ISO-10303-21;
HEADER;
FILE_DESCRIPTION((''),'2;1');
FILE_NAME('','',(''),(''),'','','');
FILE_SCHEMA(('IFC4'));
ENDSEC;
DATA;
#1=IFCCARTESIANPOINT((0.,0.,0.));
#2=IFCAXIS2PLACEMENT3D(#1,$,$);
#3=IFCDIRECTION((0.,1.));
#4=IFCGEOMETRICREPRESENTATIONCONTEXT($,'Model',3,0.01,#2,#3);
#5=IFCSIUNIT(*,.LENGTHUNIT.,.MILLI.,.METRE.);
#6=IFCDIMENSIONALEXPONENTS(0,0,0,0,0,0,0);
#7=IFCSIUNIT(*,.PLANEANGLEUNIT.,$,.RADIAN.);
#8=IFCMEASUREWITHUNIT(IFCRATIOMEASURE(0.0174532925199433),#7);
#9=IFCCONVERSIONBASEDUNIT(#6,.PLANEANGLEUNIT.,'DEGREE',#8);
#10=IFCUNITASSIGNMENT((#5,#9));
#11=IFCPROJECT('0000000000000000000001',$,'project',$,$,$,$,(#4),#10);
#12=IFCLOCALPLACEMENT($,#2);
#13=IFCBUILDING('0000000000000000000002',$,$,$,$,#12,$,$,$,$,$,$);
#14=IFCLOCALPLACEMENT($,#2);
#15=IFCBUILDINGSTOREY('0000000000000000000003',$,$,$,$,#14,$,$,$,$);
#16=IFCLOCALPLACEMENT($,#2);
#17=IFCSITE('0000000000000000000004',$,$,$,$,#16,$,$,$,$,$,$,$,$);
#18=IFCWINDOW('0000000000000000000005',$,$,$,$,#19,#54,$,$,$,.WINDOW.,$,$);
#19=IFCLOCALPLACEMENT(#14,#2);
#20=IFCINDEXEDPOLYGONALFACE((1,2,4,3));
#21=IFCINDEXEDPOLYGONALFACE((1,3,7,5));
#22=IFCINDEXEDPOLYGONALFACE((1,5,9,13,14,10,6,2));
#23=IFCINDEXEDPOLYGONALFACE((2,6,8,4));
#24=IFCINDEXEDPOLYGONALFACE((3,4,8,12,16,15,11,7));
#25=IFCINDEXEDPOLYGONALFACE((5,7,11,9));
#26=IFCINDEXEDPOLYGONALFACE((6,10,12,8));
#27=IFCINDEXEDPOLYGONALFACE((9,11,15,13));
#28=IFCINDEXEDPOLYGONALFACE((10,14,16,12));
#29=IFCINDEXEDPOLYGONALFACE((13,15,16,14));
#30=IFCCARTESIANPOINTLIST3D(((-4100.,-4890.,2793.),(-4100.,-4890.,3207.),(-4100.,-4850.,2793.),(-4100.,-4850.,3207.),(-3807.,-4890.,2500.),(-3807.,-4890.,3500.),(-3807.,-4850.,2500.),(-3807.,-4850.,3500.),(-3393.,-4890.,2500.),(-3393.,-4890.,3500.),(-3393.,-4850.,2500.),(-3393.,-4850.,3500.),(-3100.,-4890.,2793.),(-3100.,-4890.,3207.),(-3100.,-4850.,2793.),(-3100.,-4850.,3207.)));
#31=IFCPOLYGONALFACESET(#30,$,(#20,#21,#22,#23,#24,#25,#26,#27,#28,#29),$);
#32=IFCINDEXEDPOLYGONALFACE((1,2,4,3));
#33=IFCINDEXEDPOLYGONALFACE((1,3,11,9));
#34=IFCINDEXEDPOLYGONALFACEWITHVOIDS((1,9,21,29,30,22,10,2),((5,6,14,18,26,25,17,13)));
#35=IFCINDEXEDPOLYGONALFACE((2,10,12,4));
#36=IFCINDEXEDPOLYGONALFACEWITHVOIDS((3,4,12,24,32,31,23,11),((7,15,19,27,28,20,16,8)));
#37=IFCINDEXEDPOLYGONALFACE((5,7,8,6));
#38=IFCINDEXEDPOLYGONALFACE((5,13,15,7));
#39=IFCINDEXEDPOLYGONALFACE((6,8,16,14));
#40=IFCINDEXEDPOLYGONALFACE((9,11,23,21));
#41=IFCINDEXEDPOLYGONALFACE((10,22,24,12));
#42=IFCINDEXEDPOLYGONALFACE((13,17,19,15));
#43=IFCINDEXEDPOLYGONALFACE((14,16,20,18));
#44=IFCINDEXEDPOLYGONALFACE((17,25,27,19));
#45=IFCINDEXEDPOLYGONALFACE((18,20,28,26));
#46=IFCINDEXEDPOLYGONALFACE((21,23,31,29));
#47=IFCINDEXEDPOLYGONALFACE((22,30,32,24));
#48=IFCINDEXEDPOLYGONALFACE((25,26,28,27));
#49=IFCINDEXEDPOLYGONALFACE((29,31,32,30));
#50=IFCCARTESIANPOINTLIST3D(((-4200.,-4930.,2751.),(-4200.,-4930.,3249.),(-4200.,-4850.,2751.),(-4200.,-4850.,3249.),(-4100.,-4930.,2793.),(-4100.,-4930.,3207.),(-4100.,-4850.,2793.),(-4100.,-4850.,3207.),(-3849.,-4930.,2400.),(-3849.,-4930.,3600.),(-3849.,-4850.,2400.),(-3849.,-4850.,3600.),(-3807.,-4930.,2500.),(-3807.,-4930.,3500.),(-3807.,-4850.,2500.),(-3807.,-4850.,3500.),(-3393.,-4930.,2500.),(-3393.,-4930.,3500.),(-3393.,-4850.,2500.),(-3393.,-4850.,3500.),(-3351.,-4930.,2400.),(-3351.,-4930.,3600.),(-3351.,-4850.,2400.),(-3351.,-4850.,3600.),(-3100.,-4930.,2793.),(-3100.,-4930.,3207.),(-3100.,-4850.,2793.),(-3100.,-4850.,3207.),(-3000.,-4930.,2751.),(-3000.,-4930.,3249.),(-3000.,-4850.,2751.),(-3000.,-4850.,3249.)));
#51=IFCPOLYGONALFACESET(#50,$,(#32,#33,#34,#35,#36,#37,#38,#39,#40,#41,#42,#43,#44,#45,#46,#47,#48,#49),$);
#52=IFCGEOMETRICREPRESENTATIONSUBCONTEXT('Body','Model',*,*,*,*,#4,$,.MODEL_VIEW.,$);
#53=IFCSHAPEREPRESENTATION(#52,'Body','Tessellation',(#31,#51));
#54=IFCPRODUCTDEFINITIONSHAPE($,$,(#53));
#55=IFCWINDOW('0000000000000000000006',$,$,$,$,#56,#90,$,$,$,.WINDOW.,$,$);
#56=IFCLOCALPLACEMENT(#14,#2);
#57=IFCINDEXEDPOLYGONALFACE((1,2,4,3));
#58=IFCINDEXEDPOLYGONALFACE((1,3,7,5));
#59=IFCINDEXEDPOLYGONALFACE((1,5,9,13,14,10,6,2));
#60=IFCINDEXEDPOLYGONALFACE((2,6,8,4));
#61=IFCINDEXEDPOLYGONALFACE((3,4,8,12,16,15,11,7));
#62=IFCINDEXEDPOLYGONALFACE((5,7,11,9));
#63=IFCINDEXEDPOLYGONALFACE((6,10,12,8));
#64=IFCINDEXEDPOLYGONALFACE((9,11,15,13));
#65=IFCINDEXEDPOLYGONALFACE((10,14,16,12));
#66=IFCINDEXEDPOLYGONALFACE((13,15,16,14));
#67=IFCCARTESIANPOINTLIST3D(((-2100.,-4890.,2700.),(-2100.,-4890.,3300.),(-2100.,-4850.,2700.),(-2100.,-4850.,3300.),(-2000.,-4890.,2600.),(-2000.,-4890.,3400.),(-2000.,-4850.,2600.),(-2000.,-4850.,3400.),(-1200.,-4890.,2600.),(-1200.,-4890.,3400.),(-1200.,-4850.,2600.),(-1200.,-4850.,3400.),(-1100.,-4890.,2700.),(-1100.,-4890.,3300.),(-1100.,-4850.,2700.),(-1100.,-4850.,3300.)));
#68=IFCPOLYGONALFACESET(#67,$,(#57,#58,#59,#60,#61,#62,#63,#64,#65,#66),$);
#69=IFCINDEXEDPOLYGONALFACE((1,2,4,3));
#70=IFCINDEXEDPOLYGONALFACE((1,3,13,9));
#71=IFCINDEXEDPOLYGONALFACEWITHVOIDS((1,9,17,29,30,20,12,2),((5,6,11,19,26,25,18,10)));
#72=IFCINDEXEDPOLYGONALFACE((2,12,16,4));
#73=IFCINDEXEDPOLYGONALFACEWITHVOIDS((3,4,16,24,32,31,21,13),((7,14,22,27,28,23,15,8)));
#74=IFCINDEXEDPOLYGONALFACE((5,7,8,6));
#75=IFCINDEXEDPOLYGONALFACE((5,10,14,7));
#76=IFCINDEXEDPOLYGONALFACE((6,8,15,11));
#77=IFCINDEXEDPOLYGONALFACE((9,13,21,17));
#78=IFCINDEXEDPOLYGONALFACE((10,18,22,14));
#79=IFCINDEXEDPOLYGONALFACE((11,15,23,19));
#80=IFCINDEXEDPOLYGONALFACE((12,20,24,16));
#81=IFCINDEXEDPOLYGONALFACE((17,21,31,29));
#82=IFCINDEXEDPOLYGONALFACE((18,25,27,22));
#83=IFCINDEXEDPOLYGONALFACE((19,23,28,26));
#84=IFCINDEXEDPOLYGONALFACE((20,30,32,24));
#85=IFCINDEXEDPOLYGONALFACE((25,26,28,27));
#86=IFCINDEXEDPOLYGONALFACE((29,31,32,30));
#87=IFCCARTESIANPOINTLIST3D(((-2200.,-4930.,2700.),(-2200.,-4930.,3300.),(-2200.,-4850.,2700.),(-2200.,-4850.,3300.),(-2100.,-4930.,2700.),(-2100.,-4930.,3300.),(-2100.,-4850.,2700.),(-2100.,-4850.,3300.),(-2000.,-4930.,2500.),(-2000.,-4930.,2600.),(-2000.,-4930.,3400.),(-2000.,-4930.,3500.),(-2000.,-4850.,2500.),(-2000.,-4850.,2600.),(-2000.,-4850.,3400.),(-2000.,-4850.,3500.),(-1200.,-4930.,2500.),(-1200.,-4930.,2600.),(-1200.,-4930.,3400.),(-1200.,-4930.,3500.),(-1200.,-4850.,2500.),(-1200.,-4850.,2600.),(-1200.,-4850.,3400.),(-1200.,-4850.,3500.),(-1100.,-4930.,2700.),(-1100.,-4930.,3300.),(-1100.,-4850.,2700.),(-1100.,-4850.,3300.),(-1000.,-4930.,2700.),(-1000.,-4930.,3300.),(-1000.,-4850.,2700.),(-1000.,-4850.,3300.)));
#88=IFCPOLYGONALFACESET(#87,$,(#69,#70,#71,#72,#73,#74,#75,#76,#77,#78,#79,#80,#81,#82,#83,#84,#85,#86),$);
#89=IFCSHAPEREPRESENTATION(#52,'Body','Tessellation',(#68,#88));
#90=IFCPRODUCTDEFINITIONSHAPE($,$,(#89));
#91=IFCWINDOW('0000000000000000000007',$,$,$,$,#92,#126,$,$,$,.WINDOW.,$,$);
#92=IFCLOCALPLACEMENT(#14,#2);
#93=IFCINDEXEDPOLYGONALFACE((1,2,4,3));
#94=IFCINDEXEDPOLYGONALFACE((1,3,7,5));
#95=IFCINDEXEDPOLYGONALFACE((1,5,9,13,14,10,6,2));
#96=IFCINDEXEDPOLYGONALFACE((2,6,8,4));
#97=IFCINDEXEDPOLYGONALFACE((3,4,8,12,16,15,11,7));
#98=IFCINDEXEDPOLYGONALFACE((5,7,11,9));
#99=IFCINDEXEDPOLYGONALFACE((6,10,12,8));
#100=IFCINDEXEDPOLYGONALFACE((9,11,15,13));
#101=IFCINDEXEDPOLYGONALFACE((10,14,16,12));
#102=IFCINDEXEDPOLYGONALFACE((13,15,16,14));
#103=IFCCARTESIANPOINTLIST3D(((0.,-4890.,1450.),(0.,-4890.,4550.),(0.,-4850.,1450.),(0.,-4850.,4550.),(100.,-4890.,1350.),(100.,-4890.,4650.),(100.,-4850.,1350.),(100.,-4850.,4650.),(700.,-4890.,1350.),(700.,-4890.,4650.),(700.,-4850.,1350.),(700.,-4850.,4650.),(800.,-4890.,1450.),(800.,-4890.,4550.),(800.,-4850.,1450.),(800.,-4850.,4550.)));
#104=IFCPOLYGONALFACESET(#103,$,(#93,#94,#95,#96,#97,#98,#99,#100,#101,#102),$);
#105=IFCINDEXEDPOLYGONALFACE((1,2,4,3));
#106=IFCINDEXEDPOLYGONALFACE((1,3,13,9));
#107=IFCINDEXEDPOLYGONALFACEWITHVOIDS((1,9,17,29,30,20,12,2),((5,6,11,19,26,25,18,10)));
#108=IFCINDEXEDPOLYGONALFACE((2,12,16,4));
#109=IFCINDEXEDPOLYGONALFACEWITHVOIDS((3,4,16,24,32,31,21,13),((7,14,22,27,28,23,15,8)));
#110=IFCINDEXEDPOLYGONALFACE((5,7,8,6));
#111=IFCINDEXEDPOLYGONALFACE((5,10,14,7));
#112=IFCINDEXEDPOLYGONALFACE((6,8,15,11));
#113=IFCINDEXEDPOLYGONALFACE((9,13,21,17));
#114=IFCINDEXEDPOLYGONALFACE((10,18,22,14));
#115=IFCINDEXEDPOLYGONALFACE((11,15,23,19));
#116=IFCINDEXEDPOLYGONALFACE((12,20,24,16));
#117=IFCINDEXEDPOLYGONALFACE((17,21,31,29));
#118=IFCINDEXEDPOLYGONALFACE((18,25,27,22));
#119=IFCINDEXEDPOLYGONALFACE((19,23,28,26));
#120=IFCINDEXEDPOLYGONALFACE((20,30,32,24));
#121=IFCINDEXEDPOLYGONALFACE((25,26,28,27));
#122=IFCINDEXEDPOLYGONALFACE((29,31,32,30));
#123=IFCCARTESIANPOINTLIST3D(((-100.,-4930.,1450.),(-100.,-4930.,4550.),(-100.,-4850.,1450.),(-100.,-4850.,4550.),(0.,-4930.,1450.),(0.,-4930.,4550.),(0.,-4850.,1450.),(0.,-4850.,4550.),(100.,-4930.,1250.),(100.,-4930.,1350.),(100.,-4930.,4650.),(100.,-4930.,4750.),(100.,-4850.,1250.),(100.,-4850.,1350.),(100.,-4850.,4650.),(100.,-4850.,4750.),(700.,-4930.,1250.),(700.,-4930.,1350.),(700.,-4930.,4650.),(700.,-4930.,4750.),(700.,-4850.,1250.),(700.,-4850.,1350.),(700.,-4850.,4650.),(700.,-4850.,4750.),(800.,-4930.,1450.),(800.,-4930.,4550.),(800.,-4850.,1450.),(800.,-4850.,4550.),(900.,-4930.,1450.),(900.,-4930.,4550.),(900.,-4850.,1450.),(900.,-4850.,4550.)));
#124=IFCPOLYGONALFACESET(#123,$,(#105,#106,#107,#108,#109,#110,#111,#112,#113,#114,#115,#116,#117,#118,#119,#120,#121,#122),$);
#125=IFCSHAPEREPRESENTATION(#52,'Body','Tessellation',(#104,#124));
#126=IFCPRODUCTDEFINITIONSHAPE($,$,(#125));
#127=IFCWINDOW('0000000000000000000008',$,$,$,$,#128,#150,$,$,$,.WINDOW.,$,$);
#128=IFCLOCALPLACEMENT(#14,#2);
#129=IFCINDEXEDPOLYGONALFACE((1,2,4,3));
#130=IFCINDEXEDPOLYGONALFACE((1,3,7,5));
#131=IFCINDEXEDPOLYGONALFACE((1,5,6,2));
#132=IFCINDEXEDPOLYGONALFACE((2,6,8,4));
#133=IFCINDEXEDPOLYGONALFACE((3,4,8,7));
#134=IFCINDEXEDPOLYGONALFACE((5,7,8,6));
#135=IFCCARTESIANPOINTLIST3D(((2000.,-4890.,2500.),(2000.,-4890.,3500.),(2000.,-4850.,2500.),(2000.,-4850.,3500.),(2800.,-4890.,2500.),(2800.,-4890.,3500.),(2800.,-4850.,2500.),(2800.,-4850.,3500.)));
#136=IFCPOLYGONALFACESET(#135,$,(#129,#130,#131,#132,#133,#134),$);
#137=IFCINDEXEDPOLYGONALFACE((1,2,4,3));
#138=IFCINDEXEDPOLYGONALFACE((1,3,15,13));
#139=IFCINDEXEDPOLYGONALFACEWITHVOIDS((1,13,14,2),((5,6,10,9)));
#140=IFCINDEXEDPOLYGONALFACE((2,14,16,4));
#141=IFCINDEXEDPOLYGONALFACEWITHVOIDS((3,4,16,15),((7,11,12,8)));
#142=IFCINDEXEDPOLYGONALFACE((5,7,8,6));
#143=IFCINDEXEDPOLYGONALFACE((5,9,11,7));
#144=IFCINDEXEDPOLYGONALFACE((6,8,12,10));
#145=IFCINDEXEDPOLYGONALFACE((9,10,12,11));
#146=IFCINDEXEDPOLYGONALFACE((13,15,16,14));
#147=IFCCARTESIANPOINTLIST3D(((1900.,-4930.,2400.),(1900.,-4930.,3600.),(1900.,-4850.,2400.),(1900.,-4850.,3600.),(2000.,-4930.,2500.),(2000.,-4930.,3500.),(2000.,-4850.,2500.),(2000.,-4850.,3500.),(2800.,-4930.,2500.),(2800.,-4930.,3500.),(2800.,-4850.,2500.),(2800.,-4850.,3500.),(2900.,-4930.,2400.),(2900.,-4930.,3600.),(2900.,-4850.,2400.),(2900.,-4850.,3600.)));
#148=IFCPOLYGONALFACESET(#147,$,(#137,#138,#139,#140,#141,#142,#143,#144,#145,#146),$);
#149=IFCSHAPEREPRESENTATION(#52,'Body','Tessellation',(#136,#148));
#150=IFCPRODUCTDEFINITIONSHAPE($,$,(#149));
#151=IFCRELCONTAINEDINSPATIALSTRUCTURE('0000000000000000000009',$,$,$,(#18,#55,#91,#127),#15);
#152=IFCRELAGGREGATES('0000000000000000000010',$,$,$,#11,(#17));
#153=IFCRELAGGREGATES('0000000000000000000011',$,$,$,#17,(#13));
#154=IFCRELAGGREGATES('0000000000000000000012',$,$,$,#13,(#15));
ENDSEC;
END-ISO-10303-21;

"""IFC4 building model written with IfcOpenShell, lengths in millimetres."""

from ifc_helpers import new_model, entity, si_unit, converted_unit, direction, frame, origin, place, context, subcontext, project, spatial, element, save


model = new_model("IFC4")

# Units and contexts
model_context = context("Model", 3, precision=0.01, world=origin(), true_north=direction((0.0, 1.0)))
body_context = subcontext(model_context, "Body", "Model", "MODEL_VIEW")
ifc_project = project(units=[si_unit("LENGTHUNIT", "METRE", prefix="MILLI"), converted_unit("PLANEANGLEUNIT", "DEGREE", entity("IfcRatioMeasure", 0.0174532925199433), si_unit("PLANEANGLEUNIT", "RADIAN"), dimensions=[0, 0, 0, 0, 0, 0, 0])], contexts=[model_context])

# Site, building, storey
site_placement = place(None, origin())
site = spatial("IfcSite", under=ifc_project, at=site_placement)
building_placement = place(None, origin())
building = spatial("IfcBuilding", under=site, at=building_placement)
storey_placement = place(None, origin())
storey = spatial("IfcBuildingStorey", under=building, at=storey_placement)

# Shared definitions
cartesian_point_1 = entity("IfcCartesianPoint", [-500.0, -207.0])
shared_polyline_1 = entity("IfcPolyline", [cartesian_point_1, entity("IfcCartesianPoint", [-500.0, 207.0]), entity("IfcCartesianPoint", [-207.0, 500.0]), entity("IfcCartesianPoint", [207.0, 500.0]), entity("IfcCartesianPoint", [500.0, 207.0]), entity("IfcCartesianPoint", [500.0, -207.0]), entity("IfcCartesianPoint", [207.0, -500.0]), entity("IfcCartesianPoint", [-207.0, -500.0]), cartesian_point_1])
cartesian_point_2 = entity("IfcCartesianPoint", [-500.0, -300.0])
shared_polyline_2 = entity("IfcPolyline", [cartesian_point_2, entity("IfcCartesianPoint", [-500.0, 300.0]), entity("IfcCartesianPoint", [-400.0, 400.0]), entity("IfcCartesianPoint", [400.0, 400.0]), entity("IfcCartesianPoint", [500.0, 300.0]), entity("IfcCartesianPoint", [500.0, -300.0]), entity("IfcCartesianPoint", [400.0, -400.0]), entity("IfcCartesianPoint", [-400.0, -400.0]), cartesian_point_2])
cartesian_point_3 = entity("IfcCartesianPoint", [-400.0, -1550.0])
shared_polyline_3 = entity("IfcPolyline", [cartesian_point_3, entity("IfcCartesianPoint", [-400.0, 1550.0]), entity("IfcCartesianPoint", [-300.0, 1650.0]), entity("IfcCartesianPoint", [300.0, 1650.0]), entity("IfcCartesianPoint", [400.0, 1550.0]), entity("IfcCartesianPoint", [400.0, -1550.0]), entity("IfcCartesianPoint", [300.0, -1650.0]), entity("IfcCartesianPoint", [-300.0, -1650.0]), cartesian_point_3])
cartesian_point_4 = entity("IfcCartesianPoint", [-400.0, -500.0])
shared_polyline_4 = entity("IfcPolyline", [cartesian_point_4, entity("IfcCartesianPoint", [-400.0, 500.0]), entity("IfcCartesianPoint", [-400.0, 500.0]), entity("IfcCartesianPoint", [400.0, 500.0]), entity("IfcCartesianPoint", [400.0, 500.0]), entity("IfcCartesianPoint", [400.0, -500.0]), entity("IfcCartesianPoint", [400.0, -500.0]), entity("IfcCartesianPoint", [-400.0, -500.0]), cartesian_point_4])

# Shared definitions
wall_1_placement = place(storey_placement, frame((-100.0, -4900.0, 0.0), z_axis=(0.0, 0.0, 1.0), x_axis=(1.0, 0.0, 0.0)))
window_1_placement = place(wall_1_placement, frame((-3500.0, 50.0, 3000.0)))
window_2_placement = place(wall_1_placement, frame((-1500.0, 50.0, 3000.0)))
window_3_placement = place(wall_1_placement, frame((500.0, 50.0, 3000.0)))
window_4_placement = place(wall_1_placement, frame((2500.0, 50.0, 3000.0)))

# Windows
cartesian_point_5 = entity("IfcCartesianPoint", [-600.0, -249.0])
element("IfcWindow", 1, at=window_1_placement, inside=storey, PredefinedType="WINDOW", context=body_context, shape_type="SweptSolid", body=[
    entity("IfcExtrudedAreaSolid", entity("IfcArbitraryClosedProfileDef", "AREA", None, shared_polyline_1), entity("IfcAxis2Placement3D", entity("IfcCartesianPoint", [0.0, 0.0, 0.0]), entity("IfcDirection", [0.0, -1.0, 0.0]), entity("IfcDirection", [1.0, 0.0, 0.0])), entity("IfcDirection", [0.0, 0.0, 1.0]), 40.0),
    entity("IfcExtrudedAreaSolid", entity("IfcArbitraryProfileDefWithVoids", "AREA", None, entity("IfcPolyline", [cartesian_point_5, entity("IfcCartesianPoint", [-600.0, 249.0]), entity("IfcCartesianPoint", [-249.0, 600.0]), entity("IfcCartesianPoint", [249.0, 600.0]), entity("IfcCartesianPoint", [600.0, 249.0]), entity("IfcCartesianPoint", [600.0, -249.0]), entity("IfcCartesianPoint", [249.0, -600.0]), entity("IfcCartesianPoint", [-249.0, -600.0]), cartesian_point_5]), [shared_polyline_1]), entity("IfcAxis2Placement3D", entity("IfcCartesianPoint", [0.0, 0.0, 0.0]), entity("IfcDirection", [0.0, -1.0, 0.0]), entity("IfcDirection", [1.0, 0.0, 0.0])), entity("IfcDirection", [0.0, 0.0, 1.0]), 80.0),
])
cartesian_point_6 = entity("IfcCartesianPoint", [-600.0, -300.0])
element("IfcWindow", 2, at=window_2_placement, inside=storey, PredefinedType="WINDOW", context=body_context, shape_type="SweptSolid", body=[
    entity("IfcExtrudedAreaSolid", entity("IfcArbitraryClosedProfileDef", "AREA", None, shared_polyline_2), entity("IfcAxis2Placement3D", entity("IfcCartesianPoint", [0.0, 0.0, 0.0]), entity("IfcDirection", [0.0, -1.0, 0.0]), entity("IfcDirection", [1.0, 0.0, 0.0])), entity("IfcDirection", [0.0, 0.0, 1.0]), 40.0),
    entity("IfcExtrudedAreaSolid", entity("IfcArbitraryProfileDefWithVoids", "AREA", None, entity("IfcPolyline", [cartesian_point_6, entity("IfcCartesianPoint", [-600.0, 300.0]), entity("IfcCartesianPoint", [-400.0, 500.0]), entity("IfcCartesianPoint", [400.0, 500.0]), entity("IfcCartesianPoint", [600.0, 300.0]), entity("IfcCartesianPoint", [600.0, -300.0]), entity("IfcCartesianPoint", [400.0, -500.0]), entity("IfcCartesianPoint", [-400.0, -500.0]), cartesian_point_6]), [shared_polyline_2]), entity("IfcAxis2Placement3D", entity("IfcCartesianPoint", [0.0, 0.0, 0.0]), entity("IfcDirection", [0.0, -1.0, 0.0]), entity("IfcDirection", [1.0, 0.0, 0.0])), entity("IfcDirection", [0.0, 0.0, 1.0]), 80.0),
])
cartesian_point_7 = entity("IfcCartesianPoint", [-500.0, -1550.0])
element("IfcWindow", 3, at=window_3_placement, inside=storey, PredefinedType="WINDOW", context=body_context, shape_type="SweptSolid", body=[
    entity("IfcExtrudedAreaSolid", entity("IfcArbitraryClosedProfileDef", "AREA", None, shared_polyline_3), entity("IfcAxis2Placement3D", entity("IfcCartesianPoint", [0.0, 0.0, 0.0]), entity("IfcDirection", [0.0, -1.0, 0.0]), entity("IfcDirection", [1.0, 0.0, 0.0])), entity("IfcDirection", [0.0, 0.0, 1.0]), 40.0),
    entity("IfcExtrudedAreaSolid", entity("IfcArbitraryProfileDefWithVoids", "AREA", None, entity("IfcPolyline", [cartesian_point_7, entity("IfcCartesianPoint", [-500.0, 1550.0]), entity("IfcCartesianPoint", [-300.0, 1750.0]), entity("IfcCartesianPoint", [300.0, 1750.0]), entity("IfcCartesianPoint", [500.0, 1550.0]), entity("IfcCartesianPoint", [500.0, -1550.0]), entity("IfcCartesianPoint", [300.0, -1750.0]), entity("IfcCartesianPoint", [-300.0, -1750.0]), cartesian_point_7]), [shared_polyline_3]), entity("IfcAxis2Placement3D", entity("IfcCartesianPoint", [0.0, 0.0, 0.0]), entity("IfcDirection", [0.0, -1.0, 0.0]), entity("IfcDirection", [1.0, 0.0, 0.0])), entity("IfcDirection", [0.0, 0.0, 1.0]), 80.0),
])
cartesian_point_8 = entity("IfcCartesianPoint", [-500.0, -600.0])
element("IfcWindow", 4, at=window_4_placement, inside=storey, PredefinedType="WINDOW", context=body_context, shape_type="SweptSolid", body=[
    entity("IfcExtrudedAreaSolid", entity("IfcArbitraryClosedProfileDef", "AREA", None, shared_polyline_4), entity("IfcAxis2Placement3D", entity("IfcCartesianPoint", [0.0, 0.0, 0.0]), entity("IfcDirection", [0.0, -1.0, 0.0]), entity("IfcDirection", [1.0, 0.0, 0.0])), entity("IfcDirection", [0.0, 0.0, 1.0]), 40.0),
    entity("IfcExtrudedAreaSolid", entity("IfcArbitraryProfileDefWithVoids", "AREA", None, entity("IfcPolyline", [cartesian_point_8, entity("IfcCartesianPoint", [-500.0, 600.0]), entity("IfcCartesianPoint", [-500.0, 600.0]), entity("IfcCartesianPoint", [500.0, 600.0]), entity("IfcCartesianPoint", [500.0, 600.0]), entity("IfcCartesianPoint", [500.0, -600.0]), entity("IfcCartesianPoint", [500.0, -600.0]), entity("IfcCartesianPoint", [-500.0, -600.0]), cartesian_point_8]), [shared_polyline_4]), entity("IfcAxis2Placement3D", entity("IfcCartesianPoint", [0.0, 0.0, 0.0]), entity("IfcDirection", [0.0, -1.0, 0.0]), entity("IfcDirection", [1.0, 0.0, 0.0])), entity("IfcDirection", [0.0, 0.0, 1.0]), 80.0),
])

save(model, "model.ifc")
